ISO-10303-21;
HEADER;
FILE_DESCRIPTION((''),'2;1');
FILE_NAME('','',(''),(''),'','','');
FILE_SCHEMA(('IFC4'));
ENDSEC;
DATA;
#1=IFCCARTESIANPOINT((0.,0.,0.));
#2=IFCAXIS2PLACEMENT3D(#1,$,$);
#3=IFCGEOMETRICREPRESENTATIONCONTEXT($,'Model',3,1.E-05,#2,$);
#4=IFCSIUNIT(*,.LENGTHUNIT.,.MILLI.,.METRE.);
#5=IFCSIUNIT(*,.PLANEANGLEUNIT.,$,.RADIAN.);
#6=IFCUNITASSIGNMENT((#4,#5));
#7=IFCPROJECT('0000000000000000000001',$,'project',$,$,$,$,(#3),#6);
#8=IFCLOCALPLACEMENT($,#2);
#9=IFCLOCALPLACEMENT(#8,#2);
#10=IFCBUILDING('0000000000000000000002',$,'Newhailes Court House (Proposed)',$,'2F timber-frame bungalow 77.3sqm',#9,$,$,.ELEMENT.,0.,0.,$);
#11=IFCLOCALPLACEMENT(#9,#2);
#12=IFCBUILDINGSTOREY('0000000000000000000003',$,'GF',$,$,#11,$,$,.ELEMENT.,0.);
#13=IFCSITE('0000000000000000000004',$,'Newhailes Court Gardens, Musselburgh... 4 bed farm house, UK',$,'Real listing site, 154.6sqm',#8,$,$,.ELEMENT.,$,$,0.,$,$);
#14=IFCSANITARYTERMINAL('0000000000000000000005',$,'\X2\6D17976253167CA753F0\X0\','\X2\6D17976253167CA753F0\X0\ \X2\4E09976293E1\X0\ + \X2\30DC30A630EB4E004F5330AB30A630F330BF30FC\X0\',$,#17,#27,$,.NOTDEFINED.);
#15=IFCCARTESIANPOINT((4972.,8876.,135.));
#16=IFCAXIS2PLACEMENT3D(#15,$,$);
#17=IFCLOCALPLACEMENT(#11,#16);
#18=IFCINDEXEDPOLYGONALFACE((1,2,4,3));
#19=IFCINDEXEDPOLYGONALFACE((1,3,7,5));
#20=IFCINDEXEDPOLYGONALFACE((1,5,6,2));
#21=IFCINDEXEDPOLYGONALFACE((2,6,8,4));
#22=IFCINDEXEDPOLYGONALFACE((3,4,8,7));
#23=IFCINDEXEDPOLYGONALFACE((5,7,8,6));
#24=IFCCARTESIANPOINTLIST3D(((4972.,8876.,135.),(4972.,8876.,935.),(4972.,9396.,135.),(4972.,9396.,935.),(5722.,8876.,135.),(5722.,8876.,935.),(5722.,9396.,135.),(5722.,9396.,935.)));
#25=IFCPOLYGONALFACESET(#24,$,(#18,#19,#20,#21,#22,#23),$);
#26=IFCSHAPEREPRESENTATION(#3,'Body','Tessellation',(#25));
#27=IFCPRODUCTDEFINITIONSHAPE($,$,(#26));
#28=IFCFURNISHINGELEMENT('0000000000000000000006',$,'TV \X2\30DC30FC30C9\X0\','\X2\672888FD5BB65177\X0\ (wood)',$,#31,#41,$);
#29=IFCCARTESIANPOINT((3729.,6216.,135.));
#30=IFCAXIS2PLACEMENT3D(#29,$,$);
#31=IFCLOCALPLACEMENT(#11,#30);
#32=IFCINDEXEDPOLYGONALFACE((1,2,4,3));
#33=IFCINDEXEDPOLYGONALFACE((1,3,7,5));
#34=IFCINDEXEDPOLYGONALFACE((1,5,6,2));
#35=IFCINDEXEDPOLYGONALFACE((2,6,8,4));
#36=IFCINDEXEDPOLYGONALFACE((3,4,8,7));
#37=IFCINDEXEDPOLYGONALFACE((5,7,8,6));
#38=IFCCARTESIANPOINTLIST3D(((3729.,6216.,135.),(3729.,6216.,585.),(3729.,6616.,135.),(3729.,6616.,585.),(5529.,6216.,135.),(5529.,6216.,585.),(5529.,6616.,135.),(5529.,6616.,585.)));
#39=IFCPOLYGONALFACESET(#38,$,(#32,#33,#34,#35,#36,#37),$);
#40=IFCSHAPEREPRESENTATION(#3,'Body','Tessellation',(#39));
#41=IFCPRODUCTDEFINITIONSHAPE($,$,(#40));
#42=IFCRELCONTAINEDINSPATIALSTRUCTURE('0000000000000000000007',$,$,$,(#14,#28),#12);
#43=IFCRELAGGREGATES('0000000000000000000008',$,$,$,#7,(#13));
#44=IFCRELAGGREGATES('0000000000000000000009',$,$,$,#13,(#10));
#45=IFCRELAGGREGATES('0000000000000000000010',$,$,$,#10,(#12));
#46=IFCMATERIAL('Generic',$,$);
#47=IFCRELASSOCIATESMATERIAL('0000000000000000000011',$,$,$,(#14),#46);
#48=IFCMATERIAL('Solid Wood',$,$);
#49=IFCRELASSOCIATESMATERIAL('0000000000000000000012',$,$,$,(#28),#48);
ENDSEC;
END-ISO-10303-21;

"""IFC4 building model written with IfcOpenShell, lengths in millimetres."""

from ifc_helpers import new_model, si_unit, frame, frame_2d, origin, place, context, project, spatial, rectangle, extrude, material, element, save


model = new_model("IFC4")

# Units and contexts
model_context = context("Model", 3, precision=1e-05, world=origin())
ifc_project = project(units=[si_unit("LENGTHUNIT", "METRE", prefix="MILLI"), si_unit("PLANEANGLEUNIT", "RADIAN")], contexts=[model_context])

# Site, building, storey
site_placement = place(None, origin())
site = spatial("IfcSite", under=ifc_project, at=site_placement, Name="Newhailes Court Gardens, Musselburgh... 4 bed farm house, UK", ObjectType="Real listing site, 154.6sqm", CompositionType="ELEMENT", RefElevation=0.0)
building_placement = place(site_placement, origin())
building = spatial("IfcBuilding", under=site, at=building_placement, Name="Newhailes Court House (Proposed)", ObjectType="2F timber-frame bungalow 77.3sqm", CompositionType="ELEMENT", ElevationOfRefHeight=0.0, ElevationOfTerrain=0.0)
storey_placement = place(building_placement, origin())
storey = spatial("IfcBuildingStorey", under=building, at=storey_placement, Name="GF", CompositionType="ELEMENT", Elevation=0.0)

# Shared definitions
ifc_material_1 = material(Name="Solid Wood")

# Shared definitions
ifc_material_2 = material(Name="Generic")

# Sanitary terminal
sanitary_terminal_1_placement = place(storey_placement, frame((4972.0, 8876.0, 135.0)))
element("IfcSanitaryTerminal", 1, at=sanitary_terminal_1_placement, inside=storey, material=ifc_material_2, Name="洗面化粧台", Description="洗面化粧台 三面鏡 + ボウル一体カウンター", PredefinedType="NOTDEFINED", context=model_context, shape_type="SweptSolid", body=[
    extrude(rectangle(XDim=750.0, YDim=520.0, at=frame_2d((375.0, 260.0))), frame((4972.0, 8876.0, 135.0)), (0.0, 0.0, 1.0), 800.0),
])

# Furnishing element
furnishing_placement = place(storey_placement, frame((3729.0, 6216.0, 135.0)))
element("IfcFurnishingElement", 2, at=furnishing_placement, inside=storey, material=ifc_material_1, Name="TV ボード", Description="木製家具 (wood)", context=model_context, shape_type="SweptSolid", body=[
    extrude(rectangle(XDim=1800.0, YDim=400.0, at=frame_2d((900.0, 200.0))), frame((3729.0, 6216.0, 135.0)), (0.0, 0.0, 1.0), 450.0),
])

save(model, "model.ifc")
